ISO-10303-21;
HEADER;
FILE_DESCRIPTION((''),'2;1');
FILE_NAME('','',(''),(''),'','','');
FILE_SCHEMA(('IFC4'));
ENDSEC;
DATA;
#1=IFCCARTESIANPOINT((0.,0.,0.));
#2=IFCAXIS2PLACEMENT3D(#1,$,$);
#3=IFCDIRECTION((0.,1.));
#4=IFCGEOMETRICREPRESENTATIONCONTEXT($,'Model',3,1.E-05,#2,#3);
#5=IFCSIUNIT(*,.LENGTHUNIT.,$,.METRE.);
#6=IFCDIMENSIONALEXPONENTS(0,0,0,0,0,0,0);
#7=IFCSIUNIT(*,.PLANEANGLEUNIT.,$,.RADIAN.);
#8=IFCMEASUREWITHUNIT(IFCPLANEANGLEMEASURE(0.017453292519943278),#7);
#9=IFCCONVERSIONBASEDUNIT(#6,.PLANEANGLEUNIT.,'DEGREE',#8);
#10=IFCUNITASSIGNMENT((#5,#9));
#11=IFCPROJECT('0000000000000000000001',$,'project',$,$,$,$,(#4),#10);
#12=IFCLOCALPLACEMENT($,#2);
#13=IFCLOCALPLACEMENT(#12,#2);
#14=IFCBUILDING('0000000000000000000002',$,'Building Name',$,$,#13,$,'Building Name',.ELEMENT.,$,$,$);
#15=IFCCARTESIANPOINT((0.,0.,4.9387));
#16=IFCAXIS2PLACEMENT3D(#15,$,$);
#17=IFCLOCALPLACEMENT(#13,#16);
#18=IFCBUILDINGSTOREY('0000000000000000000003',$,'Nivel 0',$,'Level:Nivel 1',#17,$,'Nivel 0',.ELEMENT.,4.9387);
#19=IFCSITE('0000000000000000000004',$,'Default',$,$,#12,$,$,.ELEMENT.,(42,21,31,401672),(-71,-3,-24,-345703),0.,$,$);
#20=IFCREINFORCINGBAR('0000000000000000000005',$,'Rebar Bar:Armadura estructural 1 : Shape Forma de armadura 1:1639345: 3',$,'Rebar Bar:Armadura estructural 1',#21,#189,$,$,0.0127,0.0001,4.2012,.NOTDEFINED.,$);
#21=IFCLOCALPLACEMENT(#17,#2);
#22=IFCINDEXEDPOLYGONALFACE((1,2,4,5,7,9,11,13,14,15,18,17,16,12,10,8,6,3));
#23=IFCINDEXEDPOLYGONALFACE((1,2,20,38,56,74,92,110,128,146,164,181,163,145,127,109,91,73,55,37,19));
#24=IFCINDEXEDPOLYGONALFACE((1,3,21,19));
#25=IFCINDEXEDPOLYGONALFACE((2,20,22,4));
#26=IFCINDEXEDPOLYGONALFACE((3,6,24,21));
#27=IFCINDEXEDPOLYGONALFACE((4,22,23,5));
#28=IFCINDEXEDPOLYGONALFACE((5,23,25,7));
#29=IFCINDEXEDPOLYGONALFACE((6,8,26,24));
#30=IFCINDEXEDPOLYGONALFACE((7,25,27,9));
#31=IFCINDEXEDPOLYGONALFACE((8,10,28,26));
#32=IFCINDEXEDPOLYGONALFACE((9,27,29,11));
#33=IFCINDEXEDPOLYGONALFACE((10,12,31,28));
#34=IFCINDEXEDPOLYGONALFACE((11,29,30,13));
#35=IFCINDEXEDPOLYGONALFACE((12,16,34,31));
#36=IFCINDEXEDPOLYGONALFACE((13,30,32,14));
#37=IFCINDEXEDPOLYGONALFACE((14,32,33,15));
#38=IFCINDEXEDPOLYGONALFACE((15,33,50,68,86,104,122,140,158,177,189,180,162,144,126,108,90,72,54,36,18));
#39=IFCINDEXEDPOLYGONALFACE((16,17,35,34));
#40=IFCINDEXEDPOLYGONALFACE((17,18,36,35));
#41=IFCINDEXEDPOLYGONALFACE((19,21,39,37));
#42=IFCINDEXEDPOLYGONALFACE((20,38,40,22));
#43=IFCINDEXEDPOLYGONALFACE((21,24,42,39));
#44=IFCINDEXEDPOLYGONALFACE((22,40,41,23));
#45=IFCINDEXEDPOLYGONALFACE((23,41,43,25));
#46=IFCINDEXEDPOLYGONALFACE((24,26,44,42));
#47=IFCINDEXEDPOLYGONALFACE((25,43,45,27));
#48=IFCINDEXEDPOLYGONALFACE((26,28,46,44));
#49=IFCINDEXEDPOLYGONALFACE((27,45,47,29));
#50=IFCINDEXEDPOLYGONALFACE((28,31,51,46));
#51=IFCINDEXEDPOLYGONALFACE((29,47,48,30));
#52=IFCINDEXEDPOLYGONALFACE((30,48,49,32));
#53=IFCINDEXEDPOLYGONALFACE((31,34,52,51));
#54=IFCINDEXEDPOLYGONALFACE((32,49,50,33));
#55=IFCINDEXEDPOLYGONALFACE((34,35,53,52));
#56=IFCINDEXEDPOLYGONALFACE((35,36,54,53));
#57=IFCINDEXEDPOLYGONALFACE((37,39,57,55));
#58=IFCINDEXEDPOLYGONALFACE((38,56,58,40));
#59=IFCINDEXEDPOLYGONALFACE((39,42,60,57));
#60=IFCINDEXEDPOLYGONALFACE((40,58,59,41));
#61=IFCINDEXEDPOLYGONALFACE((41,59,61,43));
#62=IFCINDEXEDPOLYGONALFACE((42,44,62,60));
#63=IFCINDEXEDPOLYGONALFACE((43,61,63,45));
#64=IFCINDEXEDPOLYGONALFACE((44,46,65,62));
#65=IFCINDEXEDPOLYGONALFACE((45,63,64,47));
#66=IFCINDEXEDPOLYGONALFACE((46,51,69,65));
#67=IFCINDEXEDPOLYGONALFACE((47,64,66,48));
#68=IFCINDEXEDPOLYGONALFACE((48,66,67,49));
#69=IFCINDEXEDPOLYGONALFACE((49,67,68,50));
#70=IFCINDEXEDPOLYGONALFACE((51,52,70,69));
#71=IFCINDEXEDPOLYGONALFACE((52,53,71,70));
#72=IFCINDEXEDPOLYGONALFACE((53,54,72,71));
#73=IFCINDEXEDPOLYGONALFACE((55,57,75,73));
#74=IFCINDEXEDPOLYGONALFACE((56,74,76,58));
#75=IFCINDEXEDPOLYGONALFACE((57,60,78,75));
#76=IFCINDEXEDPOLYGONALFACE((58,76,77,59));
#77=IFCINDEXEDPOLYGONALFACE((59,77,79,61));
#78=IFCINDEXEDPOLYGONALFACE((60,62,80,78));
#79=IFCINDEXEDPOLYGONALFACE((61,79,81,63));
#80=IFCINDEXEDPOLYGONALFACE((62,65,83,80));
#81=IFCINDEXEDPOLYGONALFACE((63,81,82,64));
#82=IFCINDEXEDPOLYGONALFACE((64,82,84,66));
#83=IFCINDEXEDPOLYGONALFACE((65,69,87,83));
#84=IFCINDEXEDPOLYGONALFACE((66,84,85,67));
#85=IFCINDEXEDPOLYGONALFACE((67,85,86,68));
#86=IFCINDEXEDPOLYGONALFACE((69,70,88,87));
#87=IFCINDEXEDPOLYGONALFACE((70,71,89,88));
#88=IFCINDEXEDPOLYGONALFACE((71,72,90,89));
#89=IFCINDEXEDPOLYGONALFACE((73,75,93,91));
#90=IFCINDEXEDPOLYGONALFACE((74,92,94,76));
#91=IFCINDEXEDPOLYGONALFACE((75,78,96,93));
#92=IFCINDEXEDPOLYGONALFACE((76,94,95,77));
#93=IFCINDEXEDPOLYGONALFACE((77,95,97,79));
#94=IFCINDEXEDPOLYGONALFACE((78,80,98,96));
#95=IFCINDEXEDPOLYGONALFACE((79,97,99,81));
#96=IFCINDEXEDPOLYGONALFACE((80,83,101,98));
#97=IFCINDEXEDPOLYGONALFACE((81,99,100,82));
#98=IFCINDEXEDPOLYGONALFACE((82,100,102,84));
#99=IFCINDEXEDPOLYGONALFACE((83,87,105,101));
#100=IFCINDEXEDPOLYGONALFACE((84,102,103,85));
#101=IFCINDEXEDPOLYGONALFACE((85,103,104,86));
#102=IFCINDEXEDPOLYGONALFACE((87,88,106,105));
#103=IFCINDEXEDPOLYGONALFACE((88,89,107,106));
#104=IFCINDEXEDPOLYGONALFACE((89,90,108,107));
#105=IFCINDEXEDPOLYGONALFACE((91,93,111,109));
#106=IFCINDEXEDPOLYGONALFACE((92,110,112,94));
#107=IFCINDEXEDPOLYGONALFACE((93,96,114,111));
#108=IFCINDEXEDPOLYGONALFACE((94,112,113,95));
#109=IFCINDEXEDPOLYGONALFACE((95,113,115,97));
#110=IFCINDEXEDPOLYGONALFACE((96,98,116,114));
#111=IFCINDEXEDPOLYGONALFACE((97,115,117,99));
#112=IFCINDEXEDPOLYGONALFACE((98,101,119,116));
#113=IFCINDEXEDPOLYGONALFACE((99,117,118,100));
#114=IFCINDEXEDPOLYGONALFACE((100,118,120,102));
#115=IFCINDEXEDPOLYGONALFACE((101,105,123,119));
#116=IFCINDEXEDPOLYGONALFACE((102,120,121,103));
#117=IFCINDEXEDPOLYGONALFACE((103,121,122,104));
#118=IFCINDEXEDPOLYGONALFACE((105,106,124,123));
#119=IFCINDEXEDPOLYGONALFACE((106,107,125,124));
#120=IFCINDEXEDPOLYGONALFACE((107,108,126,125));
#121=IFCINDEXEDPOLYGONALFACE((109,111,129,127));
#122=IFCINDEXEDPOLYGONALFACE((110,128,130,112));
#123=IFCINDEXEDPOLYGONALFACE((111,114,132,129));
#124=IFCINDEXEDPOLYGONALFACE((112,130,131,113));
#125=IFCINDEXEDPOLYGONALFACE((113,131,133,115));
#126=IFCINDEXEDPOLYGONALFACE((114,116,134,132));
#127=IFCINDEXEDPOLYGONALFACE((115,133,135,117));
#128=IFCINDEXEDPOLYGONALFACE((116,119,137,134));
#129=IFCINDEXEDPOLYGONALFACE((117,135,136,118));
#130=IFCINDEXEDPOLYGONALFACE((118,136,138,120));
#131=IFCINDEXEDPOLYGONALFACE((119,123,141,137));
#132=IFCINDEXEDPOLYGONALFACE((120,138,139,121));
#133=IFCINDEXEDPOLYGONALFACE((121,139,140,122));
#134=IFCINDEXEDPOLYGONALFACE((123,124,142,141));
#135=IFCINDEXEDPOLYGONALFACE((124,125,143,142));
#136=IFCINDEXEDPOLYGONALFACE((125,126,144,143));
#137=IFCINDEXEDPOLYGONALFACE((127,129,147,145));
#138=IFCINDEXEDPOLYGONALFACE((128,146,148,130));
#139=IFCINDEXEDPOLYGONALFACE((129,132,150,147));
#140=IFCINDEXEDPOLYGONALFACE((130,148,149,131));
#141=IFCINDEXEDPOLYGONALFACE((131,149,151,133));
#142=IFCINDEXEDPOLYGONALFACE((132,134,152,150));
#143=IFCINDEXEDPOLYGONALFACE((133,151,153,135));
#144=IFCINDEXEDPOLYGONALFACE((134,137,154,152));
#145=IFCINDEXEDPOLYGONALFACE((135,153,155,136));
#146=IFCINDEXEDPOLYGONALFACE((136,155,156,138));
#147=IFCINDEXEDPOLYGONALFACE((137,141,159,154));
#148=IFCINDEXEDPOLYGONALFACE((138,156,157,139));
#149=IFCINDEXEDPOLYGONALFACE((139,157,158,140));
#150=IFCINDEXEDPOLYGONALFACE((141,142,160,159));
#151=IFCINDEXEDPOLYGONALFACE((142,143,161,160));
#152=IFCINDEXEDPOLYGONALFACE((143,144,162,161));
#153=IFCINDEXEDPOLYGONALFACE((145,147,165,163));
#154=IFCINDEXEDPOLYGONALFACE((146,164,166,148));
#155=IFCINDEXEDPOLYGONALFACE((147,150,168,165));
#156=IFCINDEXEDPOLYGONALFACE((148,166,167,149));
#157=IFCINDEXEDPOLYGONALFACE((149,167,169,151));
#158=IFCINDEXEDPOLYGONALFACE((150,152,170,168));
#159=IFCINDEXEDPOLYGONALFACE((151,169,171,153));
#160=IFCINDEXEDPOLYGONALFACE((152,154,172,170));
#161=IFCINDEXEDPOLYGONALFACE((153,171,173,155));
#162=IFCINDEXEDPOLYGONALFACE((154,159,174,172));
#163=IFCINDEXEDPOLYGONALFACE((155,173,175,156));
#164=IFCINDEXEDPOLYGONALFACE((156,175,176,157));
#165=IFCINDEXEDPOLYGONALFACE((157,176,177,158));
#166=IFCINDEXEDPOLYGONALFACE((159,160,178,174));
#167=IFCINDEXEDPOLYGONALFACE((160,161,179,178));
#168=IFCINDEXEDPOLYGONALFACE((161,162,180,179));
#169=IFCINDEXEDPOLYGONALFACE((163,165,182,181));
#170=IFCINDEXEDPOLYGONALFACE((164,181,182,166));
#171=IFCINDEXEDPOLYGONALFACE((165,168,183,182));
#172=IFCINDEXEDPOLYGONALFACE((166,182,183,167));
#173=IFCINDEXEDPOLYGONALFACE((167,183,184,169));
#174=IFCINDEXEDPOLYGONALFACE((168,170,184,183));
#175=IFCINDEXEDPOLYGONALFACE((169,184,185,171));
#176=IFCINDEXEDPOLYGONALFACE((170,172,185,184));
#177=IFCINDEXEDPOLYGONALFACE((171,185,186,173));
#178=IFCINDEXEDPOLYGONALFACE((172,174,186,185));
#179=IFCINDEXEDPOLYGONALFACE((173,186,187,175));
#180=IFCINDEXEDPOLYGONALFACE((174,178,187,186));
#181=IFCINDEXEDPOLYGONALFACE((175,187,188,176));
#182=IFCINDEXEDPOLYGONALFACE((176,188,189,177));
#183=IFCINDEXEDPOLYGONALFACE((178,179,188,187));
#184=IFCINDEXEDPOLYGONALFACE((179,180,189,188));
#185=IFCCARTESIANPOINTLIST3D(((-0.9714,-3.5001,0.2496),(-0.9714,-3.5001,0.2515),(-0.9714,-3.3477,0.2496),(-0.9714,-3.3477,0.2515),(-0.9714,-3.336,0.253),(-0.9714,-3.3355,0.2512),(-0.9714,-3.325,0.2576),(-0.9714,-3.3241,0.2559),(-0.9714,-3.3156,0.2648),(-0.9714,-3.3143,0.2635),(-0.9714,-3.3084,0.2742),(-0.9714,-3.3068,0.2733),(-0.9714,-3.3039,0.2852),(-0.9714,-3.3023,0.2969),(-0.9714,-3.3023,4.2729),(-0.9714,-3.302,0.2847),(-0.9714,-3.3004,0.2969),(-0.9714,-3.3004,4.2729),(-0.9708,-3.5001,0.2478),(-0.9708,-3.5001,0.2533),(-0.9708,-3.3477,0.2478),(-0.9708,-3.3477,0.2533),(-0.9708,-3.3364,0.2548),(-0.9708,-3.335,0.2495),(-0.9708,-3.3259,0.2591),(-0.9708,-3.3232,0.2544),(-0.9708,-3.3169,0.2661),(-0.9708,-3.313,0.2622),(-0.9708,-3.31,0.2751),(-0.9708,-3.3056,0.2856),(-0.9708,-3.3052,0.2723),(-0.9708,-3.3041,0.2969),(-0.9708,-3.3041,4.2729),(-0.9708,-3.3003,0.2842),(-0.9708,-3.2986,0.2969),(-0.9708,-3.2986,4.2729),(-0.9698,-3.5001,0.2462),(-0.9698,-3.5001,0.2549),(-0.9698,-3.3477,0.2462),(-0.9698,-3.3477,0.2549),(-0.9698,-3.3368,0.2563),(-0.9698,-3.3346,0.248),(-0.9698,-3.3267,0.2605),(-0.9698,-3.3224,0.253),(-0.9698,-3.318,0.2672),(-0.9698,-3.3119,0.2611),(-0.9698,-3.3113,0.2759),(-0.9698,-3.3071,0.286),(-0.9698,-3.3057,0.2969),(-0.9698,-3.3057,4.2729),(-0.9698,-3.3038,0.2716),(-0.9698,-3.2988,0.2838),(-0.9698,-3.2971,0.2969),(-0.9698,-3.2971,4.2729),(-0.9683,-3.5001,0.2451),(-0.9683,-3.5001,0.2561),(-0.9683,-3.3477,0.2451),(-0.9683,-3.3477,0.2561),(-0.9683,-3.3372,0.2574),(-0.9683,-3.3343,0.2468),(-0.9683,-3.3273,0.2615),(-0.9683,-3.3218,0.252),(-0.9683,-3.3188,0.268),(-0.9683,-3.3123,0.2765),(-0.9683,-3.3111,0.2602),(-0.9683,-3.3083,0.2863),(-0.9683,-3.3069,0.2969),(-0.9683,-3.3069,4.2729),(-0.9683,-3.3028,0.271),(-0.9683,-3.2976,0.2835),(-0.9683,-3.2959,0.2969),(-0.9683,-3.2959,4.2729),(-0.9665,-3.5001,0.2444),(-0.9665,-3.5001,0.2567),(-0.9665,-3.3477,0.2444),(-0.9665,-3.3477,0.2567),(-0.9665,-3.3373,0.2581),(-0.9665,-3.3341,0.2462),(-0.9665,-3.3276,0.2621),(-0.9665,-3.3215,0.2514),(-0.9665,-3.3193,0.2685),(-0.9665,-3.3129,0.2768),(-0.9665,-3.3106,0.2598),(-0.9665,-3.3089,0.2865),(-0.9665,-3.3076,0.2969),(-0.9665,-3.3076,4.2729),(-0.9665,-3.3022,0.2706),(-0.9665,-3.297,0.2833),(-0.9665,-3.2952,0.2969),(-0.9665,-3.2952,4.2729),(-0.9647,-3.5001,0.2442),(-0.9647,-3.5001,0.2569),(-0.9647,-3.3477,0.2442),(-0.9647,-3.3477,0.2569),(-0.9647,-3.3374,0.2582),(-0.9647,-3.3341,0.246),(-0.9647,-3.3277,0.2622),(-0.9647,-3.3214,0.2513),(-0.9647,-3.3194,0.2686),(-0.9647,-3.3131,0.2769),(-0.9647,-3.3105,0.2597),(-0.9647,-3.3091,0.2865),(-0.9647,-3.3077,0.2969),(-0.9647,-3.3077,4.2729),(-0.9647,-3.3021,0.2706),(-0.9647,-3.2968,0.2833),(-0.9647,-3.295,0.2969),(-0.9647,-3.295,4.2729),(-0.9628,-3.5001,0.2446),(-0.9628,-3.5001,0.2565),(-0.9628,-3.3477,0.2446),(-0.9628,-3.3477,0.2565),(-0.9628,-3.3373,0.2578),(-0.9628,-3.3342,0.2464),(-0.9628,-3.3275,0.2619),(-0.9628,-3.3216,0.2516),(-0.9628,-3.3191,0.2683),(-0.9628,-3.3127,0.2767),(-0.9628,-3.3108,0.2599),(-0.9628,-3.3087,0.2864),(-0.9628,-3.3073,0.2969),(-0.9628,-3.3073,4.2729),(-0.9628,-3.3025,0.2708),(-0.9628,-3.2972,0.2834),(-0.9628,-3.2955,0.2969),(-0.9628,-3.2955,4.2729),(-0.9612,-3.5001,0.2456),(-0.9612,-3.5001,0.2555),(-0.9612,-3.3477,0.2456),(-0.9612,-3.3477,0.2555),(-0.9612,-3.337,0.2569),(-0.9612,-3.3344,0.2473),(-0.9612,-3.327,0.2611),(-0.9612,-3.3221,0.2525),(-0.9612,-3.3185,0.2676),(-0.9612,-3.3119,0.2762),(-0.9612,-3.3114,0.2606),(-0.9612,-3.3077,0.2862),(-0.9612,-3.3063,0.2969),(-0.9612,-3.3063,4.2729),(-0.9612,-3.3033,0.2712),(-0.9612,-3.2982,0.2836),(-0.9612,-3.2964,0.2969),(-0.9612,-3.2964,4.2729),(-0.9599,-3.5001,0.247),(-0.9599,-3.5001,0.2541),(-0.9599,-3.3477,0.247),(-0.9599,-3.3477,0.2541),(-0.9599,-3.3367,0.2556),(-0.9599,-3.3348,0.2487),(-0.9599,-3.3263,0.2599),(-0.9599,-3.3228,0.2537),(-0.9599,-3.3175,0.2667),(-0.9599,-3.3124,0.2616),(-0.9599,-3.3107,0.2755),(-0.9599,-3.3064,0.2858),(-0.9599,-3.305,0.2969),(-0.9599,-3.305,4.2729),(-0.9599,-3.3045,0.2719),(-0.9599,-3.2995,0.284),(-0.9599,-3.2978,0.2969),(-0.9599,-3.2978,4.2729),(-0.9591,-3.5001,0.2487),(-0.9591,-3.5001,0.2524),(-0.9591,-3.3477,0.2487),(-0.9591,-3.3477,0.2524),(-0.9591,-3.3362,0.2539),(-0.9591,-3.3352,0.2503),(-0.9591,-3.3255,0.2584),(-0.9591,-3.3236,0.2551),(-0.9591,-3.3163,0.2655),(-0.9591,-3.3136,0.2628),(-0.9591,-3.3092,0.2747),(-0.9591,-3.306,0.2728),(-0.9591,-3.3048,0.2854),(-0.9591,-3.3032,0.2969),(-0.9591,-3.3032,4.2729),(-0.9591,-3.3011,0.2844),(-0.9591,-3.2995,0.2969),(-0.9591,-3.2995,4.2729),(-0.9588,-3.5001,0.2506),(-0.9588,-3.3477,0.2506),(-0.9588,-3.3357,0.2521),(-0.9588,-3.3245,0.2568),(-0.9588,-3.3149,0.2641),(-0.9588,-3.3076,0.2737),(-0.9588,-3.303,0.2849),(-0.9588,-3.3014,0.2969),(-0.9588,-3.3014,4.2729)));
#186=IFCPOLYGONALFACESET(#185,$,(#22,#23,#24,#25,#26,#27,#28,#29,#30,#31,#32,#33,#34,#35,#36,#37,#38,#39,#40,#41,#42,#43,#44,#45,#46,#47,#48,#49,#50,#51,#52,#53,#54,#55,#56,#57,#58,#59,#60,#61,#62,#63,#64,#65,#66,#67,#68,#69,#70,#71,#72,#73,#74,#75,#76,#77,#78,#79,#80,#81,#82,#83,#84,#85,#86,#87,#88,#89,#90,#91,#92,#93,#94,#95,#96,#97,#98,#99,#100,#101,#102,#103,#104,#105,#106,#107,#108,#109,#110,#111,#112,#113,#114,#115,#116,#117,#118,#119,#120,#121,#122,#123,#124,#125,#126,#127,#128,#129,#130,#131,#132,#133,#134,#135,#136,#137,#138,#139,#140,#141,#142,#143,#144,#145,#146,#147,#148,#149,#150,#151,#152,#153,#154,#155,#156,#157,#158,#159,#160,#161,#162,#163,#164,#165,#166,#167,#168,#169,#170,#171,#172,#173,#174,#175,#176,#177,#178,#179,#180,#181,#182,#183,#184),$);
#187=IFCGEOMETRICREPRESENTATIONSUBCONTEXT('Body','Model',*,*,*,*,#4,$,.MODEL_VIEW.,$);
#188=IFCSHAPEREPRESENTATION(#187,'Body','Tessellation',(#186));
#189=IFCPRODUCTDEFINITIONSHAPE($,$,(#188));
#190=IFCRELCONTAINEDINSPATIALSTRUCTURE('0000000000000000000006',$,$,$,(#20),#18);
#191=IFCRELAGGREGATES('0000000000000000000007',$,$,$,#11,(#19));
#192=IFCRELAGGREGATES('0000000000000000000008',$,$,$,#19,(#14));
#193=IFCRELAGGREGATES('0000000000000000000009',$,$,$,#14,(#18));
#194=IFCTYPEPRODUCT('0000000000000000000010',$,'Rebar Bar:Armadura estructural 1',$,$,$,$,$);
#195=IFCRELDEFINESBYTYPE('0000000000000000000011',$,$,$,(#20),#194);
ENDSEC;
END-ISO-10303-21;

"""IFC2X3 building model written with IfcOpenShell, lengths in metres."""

from ifc_helpers import new_model, entity, si_unit, converted_unit, direction, frame, origin, place, context, subcontext, project, spatial, type_object, element, save


model = new_model("IFC2X3")

# Units and contexts
model_context = context("Model", 3, precision=1e-05, world=origin(), true_north=direction((0.0, 1.0)))
body_context = subcontext(model_context, "Body", "Model", "MODEL_VIEW")
ifc_project = project(units=[si_unit("LENGTHUNIT", "METRE"), converted_unit("PLANEANGLEUNIT", "DEGREE", entity("IfcPlaneAngleMeasure", 0.017453292519943278), si_unit("PLANEANGLEUNIT", "RADIAN"), dimensions=[0, 0, 0, 0, 0, 0, 0])], contexts=[model_context])

# Site, building, storey
site_placement = place(None, origin())
site = spatial("IfcSite", under=ifc_project, at=site_placement, Name="Default", CompositionType="ELEMENT", RefLatitude=(42, 21, 31, 401672), RefLongitude=(-71, -3, -24, -345703), RefElevation=0.0)
building_placement = place(site_placement, origin())
building = spatial("IfcBuilding", under=site, at=building_placement, Name="Building Name", LongName="Building Name", CompositionType="ELEMENT")
storey_placement = place(building_placement, frame((0.0, 0.0, 4.9387)))
storey = spatial("IfcBuildingStorey", under=building, at=storey_placement, Name="Nivel 0", ObjectType="Level:Nivel 1", LongName="Nivel 0", CompositionType="ELEMENT", Elevation=4.9387)

# Reinforcing bar
type_product = type_object("IfcTypeProduct", Name="Rebar Bar:Armadura estructural 1")
reinforcing_bar_1_placement = place(storey_placement, origin())
element("IfcReinforcingBar", 1, at=reinforcing_bar_1_placement, inside=storey, type_object=type_product, Name="Rebar Bar:Armadura estructural 1 : Shape Forma de armadura 1:1639345: 3", ObjectType="Rebar Bar:Armadura estructural 1", BarLength=4.2012, BarRole="NOTDEFINED", CrossSectionArea=0.0001, NominalDiameter=0.0127, context=body_context, shape_type="AdvancedSweptSolid", body=[
    entity("IfcSweptDiskSolid", entity("IfcCompositeCurve", [entity("IfcCompositeCurveSegment", "CONTINUOUS", True, entity("IfcPolyline", [entity("IfcCartesianPoint", [-0.9651, -3.5001, 0.2506]), entity("IfcCartesianPoint", [-0.9651, -3.3477, 0.2506])])), entity("IfcCompositeCurveSegment", "CONTINUOUS", True, entity("IfcTrimmedCurve", entity("IfcCircle", entity("IfcAxis2Placement3D", entity("IfcCartesianPoint", [-0.9651, -3.3477, 0.2969]), entity("IfcDirection", [1.0, 0.0, 0.0]), entity("IfcDirection", [0.0, 1.0, 0.0])), 0.0464), [entity("IfcParameterValue", 270.0)], [entity("IfcParameterValue", 360.0)], True, "PARAMETER")), entity("IfcCompositeCurveSegment", "CONTINUOUS", True, entity("IfcPolyline", [entity("IfcCartesianPoint", [-0.9651, -3.3014, 0.2969]), entity("IfcCartesianPoint", [-0.9651, -3.3014, 4.2729])]))], False), 0.0063, None, 0.0, 92.0),
])

save(model, "model.ifc")
